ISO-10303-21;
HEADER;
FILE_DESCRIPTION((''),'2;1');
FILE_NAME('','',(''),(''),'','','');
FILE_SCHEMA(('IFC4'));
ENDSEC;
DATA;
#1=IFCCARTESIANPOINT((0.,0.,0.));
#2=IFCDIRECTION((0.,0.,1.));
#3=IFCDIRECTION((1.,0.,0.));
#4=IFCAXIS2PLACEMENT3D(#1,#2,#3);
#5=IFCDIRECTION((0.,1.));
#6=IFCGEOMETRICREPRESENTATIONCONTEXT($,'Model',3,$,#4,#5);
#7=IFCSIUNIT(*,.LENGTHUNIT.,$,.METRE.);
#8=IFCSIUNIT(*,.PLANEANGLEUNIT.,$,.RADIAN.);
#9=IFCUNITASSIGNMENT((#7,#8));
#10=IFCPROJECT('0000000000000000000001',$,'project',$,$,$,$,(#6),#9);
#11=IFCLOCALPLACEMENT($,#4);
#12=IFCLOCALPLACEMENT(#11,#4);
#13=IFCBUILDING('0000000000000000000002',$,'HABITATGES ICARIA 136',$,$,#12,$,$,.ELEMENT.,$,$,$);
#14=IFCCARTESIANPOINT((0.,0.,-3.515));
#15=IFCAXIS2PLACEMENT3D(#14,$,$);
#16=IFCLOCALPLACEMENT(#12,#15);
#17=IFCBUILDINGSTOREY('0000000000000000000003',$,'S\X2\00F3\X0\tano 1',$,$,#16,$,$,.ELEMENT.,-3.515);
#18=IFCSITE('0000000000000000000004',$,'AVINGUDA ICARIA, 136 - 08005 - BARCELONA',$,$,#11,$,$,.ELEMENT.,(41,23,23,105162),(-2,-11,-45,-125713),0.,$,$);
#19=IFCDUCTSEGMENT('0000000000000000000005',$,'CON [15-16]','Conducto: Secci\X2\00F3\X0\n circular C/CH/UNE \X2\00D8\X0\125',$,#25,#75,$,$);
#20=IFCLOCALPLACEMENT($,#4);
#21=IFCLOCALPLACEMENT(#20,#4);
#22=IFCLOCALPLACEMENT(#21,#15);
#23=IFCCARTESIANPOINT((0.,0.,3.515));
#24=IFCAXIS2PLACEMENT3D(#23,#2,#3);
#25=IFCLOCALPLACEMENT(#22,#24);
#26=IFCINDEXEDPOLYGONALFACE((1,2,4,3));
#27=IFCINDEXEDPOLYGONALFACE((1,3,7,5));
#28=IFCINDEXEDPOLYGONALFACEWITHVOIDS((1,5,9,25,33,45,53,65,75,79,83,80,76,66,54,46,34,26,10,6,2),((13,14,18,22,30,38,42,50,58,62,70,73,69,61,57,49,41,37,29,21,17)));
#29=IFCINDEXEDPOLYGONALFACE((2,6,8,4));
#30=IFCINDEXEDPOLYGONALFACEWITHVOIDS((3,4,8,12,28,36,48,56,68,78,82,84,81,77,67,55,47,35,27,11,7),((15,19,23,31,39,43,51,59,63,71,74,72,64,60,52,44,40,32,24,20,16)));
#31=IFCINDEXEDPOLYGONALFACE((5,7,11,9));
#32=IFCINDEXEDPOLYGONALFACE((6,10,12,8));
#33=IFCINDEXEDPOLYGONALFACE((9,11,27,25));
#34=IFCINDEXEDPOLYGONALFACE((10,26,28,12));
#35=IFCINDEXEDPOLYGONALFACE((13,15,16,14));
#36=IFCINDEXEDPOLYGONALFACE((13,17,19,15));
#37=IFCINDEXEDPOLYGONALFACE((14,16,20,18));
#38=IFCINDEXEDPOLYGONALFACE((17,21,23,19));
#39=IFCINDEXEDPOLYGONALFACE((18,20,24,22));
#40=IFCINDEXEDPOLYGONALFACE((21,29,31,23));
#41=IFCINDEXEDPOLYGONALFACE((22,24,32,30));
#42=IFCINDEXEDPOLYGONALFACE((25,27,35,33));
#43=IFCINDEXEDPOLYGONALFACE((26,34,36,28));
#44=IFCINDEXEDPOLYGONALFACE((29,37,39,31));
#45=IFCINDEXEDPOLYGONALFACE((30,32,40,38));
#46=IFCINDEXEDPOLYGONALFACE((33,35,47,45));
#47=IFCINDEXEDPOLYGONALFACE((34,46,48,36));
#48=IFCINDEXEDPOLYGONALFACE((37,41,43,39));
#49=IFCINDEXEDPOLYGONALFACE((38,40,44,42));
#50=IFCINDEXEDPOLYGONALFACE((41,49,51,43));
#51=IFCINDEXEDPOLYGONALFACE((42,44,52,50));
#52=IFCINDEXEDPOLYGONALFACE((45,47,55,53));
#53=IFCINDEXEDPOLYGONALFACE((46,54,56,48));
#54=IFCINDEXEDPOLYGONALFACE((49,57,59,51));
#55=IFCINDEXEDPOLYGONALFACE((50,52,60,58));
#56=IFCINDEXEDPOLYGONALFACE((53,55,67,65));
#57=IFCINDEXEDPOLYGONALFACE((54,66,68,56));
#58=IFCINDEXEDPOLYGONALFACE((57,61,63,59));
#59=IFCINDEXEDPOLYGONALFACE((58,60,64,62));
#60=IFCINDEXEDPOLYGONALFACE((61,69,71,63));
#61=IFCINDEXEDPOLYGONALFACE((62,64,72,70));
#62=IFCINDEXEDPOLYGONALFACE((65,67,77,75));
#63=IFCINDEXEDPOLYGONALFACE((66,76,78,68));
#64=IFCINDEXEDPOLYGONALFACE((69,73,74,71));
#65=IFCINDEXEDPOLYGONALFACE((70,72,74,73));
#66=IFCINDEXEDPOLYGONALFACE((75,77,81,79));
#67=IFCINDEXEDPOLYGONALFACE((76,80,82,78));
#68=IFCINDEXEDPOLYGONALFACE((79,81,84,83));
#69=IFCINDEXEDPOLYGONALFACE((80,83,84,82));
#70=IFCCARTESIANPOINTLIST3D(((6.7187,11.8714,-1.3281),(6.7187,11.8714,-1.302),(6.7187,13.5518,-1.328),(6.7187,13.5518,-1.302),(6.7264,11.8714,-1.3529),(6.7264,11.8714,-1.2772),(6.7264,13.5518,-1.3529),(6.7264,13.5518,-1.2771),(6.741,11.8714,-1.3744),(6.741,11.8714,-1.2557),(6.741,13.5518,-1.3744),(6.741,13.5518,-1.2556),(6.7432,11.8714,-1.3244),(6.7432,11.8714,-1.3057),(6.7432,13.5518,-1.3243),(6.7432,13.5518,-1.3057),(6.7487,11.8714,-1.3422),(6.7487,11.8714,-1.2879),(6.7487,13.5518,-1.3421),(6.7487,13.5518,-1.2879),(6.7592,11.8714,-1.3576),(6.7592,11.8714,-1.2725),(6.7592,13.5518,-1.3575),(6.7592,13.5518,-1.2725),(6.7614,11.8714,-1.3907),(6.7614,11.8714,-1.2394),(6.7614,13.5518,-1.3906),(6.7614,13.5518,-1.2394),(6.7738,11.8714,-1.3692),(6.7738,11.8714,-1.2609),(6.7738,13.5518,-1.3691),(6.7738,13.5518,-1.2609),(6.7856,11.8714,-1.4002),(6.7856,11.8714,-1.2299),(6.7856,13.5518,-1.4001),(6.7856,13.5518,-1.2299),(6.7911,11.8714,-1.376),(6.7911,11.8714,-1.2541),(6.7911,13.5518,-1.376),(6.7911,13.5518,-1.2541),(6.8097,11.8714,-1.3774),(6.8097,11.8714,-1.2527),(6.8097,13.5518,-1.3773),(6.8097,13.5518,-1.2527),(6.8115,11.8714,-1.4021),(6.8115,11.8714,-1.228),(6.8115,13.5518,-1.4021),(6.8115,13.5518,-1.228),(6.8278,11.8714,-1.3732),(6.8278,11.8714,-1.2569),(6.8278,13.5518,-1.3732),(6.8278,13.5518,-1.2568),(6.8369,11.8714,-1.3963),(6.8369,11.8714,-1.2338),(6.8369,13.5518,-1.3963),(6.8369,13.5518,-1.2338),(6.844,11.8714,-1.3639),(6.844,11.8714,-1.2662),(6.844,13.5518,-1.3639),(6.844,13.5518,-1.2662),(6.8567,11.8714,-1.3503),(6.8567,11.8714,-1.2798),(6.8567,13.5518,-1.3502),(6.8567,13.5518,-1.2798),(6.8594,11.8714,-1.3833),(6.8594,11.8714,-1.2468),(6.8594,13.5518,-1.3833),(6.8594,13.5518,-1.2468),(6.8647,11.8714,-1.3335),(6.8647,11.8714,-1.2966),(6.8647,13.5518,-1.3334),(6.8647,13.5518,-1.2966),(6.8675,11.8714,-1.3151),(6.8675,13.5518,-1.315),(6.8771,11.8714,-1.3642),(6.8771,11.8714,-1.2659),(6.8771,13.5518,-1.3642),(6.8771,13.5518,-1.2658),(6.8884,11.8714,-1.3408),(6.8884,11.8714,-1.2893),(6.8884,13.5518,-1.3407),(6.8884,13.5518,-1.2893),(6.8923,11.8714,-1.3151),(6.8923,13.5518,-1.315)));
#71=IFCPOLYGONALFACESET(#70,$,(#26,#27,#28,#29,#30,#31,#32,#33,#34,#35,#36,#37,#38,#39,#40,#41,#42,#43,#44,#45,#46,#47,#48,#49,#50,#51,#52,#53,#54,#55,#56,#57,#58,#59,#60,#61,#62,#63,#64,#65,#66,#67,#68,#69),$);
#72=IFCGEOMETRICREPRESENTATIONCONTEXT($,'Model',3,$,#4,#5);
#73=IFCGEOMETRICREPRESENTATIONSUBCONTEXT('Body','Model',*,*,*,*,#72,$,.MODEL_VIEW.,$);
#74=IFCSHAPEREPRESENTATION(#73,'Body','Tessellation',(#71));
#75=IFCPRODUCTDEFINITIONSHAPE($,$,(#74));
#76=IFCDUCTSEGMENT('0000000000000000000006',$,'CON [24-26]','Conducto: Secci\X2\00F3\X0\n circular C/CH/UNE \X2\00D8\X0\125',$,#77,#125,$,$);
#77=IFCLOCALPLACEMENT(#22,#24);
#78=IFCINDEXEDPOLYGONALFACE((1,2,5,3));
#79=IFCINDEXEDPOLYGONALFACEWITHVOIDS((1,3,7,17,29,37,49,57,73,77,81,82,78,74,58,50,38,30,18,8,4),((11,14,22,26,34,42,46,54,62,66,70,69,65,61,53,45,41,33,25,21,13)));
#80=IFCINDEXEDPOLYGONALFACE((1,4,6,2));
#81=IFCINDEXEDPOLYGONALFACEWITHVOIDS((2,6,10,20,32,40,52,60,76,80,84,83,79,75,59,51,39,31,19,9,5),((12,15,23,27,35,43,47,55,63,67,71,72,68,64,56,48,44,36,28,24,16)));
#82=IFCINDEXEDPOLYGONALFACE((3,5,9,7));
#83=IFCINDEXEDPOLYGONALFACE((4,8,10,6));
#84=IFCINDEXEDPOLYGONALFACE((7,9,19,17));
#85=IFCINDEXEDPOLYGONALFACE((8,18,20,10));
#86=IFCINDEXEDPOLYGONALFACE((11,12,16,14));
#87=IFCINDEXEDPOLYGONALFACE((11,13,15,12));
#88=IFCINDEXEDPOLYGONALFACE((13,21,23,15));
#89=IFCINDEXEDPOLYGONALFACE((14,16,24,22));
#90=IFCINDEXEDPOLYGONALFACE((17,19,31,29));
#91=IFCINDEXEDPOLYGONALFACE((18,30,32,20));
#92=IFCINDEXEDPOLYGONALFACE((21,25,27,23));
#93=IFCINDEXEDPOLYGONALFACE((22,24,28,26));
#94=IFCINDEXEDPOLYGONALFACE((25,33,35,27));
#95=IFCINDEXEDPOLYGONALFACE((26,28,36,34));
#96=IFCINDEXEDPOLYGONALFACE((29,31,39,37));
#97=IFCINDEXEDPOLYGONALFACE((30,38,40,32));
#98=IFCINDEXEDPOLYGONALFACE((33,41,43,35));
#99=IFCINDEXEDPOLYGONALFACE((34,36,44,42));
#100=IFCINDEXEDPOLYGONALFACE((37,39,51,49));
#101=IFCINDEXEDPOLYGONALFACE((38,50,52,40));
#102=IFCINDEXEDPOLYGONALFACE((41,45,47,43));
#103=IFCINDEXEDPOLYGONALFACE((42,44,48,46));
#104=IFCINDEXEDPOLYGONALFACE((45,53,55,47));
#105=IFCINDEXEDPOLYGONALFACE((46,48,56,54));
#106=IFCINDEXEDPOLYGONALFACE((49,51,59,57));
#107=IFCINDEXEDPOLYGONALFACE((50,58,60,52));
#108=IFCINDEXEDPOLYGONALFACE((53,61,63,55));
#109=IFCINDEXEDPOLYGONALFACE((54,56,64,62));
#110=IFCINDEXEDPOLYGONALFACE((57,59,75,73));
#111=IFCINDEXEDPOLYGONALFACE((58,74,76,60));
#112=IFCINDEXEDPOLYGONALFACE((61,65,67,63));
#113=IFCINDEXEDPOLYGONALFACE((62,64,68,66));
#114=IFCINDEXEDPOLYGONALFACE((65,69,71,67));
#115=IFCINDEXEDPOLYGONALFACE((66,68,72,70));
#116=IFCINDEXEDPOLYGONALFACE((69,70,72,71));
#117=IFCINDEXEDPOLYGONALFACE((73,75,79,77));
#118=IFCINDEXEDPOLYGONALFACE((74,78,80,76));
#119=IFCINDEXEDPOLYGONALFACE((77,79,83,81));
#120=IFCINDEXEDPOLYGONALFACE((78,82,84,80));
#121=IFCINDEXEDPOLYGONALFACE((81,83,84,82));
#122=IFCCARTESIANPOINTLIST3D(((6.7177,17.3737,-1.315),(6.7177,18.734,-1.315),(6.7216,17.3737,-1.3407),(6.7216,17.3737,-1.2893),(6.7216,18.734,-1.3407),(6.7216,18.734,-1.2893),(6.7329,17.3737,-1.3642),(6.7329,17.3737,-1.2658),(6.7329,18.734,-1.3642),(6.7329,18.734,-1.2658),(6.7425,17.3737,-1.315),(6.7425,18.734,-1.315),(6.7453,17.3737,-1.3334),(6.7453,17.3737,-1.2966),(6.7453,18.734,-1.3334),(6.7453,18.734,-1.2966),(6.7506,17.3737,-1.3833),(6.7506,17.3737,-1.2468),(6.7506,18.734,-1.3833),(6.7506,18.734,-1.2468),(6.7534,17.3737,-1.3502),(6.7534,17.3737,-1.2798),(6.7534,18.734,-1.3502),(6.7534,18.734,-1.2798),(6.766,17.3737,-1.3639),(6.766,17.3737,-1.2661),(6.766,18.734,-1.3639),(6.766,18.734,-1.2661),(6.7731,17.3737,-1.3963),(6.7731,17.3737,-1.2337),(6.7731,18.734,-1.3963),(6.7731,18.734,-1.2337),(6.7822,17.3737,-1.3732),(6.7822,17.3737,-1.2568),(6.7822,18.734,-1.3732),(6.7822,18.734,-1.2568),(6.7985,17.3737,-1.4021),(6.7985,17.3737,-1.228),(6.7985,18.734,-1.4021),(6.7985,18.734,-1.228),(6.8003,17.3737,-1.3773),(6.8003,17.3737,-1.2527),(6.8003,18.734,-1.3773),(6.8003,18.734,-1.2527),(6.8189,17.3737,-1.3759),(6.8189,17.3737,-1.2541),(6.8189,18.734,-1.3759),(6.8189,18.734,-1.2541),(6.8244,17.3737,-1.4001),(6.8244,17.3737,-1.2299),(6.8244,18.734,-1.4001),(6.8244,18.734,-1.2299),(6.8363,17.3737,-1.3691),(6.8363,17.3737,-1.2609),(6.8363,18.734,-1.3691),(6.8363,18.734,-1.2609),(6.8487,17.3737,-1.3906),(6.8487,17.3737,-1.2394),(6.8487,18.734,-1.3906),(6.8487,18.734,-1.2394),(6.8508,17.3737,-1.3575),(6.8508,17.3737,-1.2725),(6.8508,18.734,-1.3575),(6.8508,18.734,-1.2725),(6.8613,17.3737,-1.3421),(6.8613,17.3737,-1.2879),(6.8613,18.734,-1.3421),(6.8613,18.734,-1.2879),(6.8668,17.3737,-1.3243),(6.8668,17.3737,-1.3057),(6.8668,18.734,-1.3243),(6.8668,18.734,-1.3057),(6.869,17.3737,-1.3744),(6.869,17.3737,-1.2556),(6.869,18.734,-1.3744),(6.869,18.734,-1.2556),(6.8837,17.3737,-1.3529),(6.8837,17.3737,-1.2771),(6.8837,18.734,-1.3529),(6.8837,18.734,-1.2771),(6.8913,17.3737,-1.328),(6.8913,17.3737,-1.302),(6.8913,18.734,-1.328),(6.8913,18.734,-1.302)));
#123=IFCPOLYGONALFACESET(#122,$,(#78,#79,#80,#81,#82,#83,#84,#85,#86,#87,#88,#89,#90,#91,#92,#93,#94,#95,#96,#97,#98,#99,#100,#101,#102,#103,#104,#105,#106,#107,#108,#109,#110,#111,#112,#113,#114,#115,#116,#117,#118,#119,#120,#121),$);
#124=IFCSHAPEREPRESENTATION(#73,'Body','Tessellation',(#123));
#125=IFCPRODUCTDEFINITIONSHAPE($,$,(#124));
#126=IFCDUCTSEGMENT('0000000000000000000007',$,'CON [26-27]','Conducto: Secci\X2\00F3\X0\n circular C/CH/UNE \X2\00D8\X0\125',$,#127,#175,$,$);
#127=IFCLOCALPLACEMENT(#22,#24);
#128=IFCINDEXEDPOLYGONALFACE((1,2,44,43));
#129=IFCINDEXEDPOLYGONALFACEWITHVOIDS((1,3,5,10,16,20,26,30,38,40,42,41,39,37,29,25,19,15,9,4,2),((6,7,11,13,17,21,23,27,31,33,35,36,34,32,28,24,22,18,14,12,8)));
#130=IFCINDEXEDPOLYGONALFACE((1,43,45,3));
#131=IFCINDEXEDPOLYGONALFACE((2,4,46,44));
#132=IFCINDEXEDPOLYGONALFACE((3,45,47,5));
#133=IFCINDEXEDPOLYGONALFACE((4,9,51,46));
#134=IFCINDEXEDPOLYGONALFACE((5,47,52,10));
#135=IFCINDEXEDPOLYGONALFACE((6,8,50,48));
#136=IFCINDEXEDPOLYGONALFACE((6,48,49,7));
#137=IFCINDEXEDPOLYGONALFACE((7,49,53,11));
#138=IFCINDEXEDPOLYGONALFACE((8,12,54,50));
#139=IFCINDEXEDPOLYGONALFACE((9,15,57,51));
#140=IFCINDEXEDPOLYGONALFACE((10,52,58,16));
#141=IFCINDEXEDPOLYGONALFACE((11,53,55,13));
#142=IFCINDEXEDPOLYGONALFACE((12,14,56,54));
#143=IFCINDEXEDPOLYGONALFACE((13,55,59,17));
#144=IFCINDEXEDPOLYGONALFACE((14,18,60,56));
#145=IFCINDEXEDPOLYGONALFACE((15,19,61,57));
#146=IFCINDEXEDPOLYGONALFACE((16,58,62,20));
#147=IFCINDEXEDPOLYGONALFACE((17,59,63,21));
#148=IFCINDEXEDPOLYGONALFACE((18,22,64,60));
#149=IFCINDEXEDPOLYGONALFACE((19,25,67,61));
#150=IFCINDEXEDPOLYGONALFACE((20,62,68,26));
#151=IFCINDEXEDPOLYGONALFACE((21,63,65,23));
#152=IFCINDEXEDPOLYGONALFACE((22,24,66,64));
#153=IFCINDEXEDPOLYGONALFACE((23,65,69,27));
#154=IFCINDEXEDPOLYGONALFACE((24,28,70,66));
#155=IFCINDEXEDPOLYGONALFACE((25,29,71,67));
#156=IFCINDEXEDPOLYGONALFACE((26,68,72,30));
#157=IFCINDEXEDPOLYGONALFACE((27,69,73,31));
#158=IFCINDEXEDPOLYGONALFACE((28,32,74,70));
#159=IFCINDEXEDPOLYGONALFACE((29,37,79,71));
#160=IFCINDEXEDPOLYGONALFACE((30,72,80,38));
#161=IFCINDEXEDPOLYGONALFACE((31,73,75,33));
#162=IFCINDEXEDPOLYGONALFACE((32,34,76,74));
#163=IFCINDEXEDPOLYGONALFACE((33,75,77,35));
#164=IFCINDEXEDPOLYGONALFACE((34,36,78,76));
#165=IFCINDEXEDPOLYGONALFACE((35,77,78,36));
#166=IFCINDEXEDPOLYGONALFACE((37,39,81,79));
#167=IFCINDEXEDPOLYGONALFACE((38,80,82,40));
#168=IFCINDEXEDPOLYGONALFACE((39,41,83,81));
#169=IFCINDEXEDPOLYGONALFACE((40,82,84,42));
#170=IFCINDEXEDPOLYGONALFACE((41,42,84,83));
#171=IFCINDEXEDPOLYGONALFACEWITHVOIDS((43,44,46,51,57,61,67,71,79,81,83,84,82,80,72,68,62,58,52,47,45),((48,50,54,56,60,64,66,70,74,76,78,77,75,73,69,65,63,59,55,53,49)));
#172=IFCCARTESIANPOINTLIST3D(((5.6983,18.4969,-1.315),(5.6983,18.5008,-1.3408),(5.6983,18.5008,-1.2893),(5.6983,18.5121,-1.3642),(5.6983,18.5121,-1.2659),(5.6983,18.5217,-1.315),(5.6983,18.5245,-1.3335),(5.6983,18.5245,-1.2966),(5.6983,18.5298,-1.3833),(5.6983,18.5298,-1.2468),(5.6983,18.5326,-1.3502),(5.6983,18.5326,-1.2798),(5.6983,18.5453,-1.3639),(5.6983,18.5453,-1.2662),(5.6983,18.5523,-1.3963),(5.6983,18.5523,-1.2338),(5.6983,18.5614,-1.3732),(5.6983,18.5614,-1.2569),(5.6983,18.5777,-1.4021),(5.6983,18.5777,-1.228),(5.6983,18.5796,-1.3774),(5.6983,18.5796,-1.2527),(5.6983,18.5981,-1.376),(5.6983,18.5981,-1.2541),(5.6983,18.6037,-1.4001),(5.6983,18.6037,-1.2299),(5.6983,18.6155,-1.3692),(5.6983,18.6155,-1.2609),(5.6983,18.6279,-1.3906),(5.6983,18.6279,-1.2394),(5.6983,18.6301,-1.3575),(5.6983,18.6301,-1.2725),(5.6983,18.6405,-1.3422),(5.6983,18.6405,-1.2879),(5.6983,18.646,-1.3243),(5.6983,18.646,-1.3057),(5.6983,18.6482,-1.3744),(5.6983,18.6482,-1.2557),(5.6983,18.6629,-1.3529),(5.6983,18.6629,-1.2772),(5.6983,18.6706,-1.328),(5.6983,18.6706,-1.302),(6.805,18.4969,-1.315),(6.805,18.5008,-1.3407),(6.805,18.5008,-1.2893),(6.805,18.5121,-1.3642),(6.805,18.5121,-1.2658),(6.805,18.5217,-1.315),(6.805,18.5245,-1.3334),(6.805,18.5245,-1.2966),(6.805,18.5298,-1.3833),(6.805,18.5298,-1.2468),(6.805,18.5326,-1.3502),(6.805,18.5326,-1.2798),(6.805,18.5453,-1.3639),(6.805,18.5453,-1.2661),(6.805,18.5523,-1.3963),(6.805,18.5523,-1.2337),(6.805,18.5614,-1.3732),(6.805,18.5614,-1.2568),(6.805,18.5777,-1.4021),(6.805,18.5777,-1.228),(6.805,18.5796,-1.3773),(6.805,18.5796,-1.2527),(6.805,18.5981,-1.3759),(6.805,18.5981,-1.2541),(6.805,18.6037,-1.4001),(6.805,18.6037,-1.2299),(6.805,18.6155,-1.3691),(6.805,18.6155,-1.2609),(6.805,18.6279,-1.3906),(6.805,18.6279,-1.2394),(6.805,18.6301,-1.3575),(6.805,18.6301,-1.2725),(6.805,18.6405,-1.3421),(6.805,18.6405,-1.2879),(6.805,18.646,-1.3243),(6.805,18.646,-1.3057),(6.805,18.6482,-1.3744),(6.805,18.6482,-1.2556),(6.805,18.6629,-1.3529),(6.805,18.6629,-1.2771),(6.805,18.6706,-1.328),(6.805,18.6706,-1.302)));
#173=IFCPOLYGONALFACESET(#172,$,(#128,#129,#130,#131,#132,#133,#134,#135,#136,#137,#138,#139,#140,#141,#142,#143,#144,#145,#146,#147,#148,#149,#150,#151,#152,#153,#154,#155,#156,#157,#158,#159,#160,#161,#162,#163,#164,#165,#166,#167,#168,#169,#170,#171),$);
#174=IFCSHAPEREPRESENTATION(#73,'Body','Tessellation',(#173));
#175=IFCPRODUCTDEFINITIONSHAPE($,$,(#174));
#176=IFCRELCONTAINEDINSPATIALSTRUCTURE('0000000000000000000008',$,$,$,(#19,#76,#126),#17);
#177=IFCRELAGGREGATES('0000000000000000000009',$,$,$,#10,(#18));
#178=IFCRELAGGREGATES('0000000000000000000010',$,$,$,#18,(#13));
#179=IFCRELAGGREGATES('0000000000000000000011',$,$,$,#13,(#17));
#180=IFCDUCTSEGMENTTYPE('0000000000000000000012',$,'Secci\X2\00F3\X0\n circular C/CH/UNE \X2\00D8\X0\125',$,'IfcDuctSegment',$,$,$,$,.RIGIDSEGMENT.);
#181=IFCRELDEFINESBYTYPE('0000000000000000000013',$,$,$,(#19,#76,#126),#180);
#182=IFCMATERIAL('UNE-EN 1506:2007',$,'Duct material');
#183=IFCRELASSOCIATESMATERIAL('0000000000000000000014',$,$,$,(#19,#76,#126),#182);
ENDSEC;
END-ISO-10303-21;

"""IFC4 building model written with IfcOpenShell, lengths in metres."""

from ifc_helpers import new_model, si_unit, direction, frame, origin_with_axes, origin_2d_with_axis, place, context, subcontext, project, spatial, hollow_circle, extrude, material, type_object, element, save


model = new_model("IFC4")

# Units and contexts
model_context_1 = context("Model", 3, world=origin_with_axes(), true_north=direction((0.0, 1.0)))
model_context_2 = context("Model", 3, world=origin_with_axes(), true_north=direction((0.0, 1.0)))
body_context_1 = subcontext(model_context_2, "Body", "Model", "MODEL_VIEW")
ifc_project = project(units=[si_unit("LENGTHUNIT", "METRE"), si_unit("PLANEANGLEUNIT", "RADIAN")], contexts=[model_context_1])

# Site, building, storey
site_placement = place(None, origin_with_axes())
site = spatial("IfcSite", under=ifc_project, at=site_placement, Name="AVINGUDA ICARIA, 136 - 08005 - BARCELONA", CompositionType="ELEMENT", RefLatitude=(41, 23, 23, 105162), RefLongitude=(-2, -11, -45, -125713), RefElevation=0.0)
building_placement = place(site_placement, origin_with_axes())
building = spatial("IfcBuilding", under=site, at=building_placement, Name="HABITATGES ICARIA 136", CompositionType="ELEMENT")
storey_placement = place(building_placement, frame((0.0, 0.0, -3.515)))
storey = spatial("IfcBuildingStorey", under=building, at=storey_placement, Name="Sótano 1", CompositionType="ELEMENT", Elevation=-3.515)

# Duct segments
ifc_material_1 = material(Name="UNE-EN 1506:2007", Category="Duct material")
duct_segment_type = type_object("IfcDuctSegmentType", Name="Sección circular C/CH/UNE Ø125", ApplicableOccurrence="IfcDuctSegment", PredefinedType="RIGIDSEGMENT")
placement_1 = place(None, origin_with_axes())
placement_2 = place(placement_1, origin_with_axes())
placement_3 = place(placement_2, frame((0.0, 0.0, -3.515)))
duct_segment_1_placement = place(placement_3, frame((0.0, 0.0, 3.515), z_axis=(0.0, 0.0, 1.0), x_axis=(1.0, 0.0, 0.0)))
element("IfcDuctSegment", 1, at=duct_segment_1_placement, inside=storey, type_object=duct_segment_type, material=ifc_material_1, Name="CON [15-16]", Description="Conducto: Sección circular C/CH/UNE Ø125", context=body_context_1, shape_type="SweptSolid", body=[
    extrude(hollow_circle(Radius=0.0873, WallThickness=0.0248, at=origin_2d_with_axis()), frame((6.805, 13.5518, -1.315), z_axis=(0.0, -1.0, -0.00002), x_axis=(1.0, 0.0, 0.0)), (0.0, 0.0, 1.0), 1.6804),
])
duct_segment_2_placement = place(placement_3, frame((0.0, 0.0, 3.515), z_axis=(0.0, 0.0, 1.0), x_axis=(1.0, 0.0, 0.0)))
element("IfcDuctSegment", 2, at=duct_segment_2_placement, inside=storey, type_object=duct_segment_type, material=ifc_material_1, Name="CON [24-26]", Description="Conducto: Sección circular C/CH/UNE Ø125", context=body_context_1, shape_type="SweptSolid", body=[
    extrude(hollow_circle(Radius=0.0873, WallThickness=0.0248, at=origin_2d_with_axis()), frame((6.805, 17.3737, -1.315), z_axis=(0.0, 1.0, 0.0), x_axis=(-1.0, 0.0, 0.0)), (0.0, 0.0, 1.0), 1.3604),
])
duct_segment_3_placement = place(placement_3, frame((0.0, 0.0, 3.515), z_axis=(0.0, 0.0, 1.0), x_axis=(1.0, 0.0, 0.0)))
element("IfcDuctSegment", 3, at=duct_segment_3_placement, inside=storey, type_object=duct_segment_type, material=ifc_material_1, Name="CON [26-27]", Description="Conducto: Sección circular C/CH/UNE Ø125", context=body_context_1, shape_type="SweptSolid", body=[
    extrude(hollow_circle(Radius=0.0873, WallThickness=0.0248, at=origin_2d_with_axis()), frame((6.805, 18.5842, -1.315), z_axis=(-1.0, 0.0, -0.000017), x_axis=(0.0, -1.0, 0.0)), (0.0, 0.0, 1.0), 1.1067),
])

save(model, "model.ifc")
